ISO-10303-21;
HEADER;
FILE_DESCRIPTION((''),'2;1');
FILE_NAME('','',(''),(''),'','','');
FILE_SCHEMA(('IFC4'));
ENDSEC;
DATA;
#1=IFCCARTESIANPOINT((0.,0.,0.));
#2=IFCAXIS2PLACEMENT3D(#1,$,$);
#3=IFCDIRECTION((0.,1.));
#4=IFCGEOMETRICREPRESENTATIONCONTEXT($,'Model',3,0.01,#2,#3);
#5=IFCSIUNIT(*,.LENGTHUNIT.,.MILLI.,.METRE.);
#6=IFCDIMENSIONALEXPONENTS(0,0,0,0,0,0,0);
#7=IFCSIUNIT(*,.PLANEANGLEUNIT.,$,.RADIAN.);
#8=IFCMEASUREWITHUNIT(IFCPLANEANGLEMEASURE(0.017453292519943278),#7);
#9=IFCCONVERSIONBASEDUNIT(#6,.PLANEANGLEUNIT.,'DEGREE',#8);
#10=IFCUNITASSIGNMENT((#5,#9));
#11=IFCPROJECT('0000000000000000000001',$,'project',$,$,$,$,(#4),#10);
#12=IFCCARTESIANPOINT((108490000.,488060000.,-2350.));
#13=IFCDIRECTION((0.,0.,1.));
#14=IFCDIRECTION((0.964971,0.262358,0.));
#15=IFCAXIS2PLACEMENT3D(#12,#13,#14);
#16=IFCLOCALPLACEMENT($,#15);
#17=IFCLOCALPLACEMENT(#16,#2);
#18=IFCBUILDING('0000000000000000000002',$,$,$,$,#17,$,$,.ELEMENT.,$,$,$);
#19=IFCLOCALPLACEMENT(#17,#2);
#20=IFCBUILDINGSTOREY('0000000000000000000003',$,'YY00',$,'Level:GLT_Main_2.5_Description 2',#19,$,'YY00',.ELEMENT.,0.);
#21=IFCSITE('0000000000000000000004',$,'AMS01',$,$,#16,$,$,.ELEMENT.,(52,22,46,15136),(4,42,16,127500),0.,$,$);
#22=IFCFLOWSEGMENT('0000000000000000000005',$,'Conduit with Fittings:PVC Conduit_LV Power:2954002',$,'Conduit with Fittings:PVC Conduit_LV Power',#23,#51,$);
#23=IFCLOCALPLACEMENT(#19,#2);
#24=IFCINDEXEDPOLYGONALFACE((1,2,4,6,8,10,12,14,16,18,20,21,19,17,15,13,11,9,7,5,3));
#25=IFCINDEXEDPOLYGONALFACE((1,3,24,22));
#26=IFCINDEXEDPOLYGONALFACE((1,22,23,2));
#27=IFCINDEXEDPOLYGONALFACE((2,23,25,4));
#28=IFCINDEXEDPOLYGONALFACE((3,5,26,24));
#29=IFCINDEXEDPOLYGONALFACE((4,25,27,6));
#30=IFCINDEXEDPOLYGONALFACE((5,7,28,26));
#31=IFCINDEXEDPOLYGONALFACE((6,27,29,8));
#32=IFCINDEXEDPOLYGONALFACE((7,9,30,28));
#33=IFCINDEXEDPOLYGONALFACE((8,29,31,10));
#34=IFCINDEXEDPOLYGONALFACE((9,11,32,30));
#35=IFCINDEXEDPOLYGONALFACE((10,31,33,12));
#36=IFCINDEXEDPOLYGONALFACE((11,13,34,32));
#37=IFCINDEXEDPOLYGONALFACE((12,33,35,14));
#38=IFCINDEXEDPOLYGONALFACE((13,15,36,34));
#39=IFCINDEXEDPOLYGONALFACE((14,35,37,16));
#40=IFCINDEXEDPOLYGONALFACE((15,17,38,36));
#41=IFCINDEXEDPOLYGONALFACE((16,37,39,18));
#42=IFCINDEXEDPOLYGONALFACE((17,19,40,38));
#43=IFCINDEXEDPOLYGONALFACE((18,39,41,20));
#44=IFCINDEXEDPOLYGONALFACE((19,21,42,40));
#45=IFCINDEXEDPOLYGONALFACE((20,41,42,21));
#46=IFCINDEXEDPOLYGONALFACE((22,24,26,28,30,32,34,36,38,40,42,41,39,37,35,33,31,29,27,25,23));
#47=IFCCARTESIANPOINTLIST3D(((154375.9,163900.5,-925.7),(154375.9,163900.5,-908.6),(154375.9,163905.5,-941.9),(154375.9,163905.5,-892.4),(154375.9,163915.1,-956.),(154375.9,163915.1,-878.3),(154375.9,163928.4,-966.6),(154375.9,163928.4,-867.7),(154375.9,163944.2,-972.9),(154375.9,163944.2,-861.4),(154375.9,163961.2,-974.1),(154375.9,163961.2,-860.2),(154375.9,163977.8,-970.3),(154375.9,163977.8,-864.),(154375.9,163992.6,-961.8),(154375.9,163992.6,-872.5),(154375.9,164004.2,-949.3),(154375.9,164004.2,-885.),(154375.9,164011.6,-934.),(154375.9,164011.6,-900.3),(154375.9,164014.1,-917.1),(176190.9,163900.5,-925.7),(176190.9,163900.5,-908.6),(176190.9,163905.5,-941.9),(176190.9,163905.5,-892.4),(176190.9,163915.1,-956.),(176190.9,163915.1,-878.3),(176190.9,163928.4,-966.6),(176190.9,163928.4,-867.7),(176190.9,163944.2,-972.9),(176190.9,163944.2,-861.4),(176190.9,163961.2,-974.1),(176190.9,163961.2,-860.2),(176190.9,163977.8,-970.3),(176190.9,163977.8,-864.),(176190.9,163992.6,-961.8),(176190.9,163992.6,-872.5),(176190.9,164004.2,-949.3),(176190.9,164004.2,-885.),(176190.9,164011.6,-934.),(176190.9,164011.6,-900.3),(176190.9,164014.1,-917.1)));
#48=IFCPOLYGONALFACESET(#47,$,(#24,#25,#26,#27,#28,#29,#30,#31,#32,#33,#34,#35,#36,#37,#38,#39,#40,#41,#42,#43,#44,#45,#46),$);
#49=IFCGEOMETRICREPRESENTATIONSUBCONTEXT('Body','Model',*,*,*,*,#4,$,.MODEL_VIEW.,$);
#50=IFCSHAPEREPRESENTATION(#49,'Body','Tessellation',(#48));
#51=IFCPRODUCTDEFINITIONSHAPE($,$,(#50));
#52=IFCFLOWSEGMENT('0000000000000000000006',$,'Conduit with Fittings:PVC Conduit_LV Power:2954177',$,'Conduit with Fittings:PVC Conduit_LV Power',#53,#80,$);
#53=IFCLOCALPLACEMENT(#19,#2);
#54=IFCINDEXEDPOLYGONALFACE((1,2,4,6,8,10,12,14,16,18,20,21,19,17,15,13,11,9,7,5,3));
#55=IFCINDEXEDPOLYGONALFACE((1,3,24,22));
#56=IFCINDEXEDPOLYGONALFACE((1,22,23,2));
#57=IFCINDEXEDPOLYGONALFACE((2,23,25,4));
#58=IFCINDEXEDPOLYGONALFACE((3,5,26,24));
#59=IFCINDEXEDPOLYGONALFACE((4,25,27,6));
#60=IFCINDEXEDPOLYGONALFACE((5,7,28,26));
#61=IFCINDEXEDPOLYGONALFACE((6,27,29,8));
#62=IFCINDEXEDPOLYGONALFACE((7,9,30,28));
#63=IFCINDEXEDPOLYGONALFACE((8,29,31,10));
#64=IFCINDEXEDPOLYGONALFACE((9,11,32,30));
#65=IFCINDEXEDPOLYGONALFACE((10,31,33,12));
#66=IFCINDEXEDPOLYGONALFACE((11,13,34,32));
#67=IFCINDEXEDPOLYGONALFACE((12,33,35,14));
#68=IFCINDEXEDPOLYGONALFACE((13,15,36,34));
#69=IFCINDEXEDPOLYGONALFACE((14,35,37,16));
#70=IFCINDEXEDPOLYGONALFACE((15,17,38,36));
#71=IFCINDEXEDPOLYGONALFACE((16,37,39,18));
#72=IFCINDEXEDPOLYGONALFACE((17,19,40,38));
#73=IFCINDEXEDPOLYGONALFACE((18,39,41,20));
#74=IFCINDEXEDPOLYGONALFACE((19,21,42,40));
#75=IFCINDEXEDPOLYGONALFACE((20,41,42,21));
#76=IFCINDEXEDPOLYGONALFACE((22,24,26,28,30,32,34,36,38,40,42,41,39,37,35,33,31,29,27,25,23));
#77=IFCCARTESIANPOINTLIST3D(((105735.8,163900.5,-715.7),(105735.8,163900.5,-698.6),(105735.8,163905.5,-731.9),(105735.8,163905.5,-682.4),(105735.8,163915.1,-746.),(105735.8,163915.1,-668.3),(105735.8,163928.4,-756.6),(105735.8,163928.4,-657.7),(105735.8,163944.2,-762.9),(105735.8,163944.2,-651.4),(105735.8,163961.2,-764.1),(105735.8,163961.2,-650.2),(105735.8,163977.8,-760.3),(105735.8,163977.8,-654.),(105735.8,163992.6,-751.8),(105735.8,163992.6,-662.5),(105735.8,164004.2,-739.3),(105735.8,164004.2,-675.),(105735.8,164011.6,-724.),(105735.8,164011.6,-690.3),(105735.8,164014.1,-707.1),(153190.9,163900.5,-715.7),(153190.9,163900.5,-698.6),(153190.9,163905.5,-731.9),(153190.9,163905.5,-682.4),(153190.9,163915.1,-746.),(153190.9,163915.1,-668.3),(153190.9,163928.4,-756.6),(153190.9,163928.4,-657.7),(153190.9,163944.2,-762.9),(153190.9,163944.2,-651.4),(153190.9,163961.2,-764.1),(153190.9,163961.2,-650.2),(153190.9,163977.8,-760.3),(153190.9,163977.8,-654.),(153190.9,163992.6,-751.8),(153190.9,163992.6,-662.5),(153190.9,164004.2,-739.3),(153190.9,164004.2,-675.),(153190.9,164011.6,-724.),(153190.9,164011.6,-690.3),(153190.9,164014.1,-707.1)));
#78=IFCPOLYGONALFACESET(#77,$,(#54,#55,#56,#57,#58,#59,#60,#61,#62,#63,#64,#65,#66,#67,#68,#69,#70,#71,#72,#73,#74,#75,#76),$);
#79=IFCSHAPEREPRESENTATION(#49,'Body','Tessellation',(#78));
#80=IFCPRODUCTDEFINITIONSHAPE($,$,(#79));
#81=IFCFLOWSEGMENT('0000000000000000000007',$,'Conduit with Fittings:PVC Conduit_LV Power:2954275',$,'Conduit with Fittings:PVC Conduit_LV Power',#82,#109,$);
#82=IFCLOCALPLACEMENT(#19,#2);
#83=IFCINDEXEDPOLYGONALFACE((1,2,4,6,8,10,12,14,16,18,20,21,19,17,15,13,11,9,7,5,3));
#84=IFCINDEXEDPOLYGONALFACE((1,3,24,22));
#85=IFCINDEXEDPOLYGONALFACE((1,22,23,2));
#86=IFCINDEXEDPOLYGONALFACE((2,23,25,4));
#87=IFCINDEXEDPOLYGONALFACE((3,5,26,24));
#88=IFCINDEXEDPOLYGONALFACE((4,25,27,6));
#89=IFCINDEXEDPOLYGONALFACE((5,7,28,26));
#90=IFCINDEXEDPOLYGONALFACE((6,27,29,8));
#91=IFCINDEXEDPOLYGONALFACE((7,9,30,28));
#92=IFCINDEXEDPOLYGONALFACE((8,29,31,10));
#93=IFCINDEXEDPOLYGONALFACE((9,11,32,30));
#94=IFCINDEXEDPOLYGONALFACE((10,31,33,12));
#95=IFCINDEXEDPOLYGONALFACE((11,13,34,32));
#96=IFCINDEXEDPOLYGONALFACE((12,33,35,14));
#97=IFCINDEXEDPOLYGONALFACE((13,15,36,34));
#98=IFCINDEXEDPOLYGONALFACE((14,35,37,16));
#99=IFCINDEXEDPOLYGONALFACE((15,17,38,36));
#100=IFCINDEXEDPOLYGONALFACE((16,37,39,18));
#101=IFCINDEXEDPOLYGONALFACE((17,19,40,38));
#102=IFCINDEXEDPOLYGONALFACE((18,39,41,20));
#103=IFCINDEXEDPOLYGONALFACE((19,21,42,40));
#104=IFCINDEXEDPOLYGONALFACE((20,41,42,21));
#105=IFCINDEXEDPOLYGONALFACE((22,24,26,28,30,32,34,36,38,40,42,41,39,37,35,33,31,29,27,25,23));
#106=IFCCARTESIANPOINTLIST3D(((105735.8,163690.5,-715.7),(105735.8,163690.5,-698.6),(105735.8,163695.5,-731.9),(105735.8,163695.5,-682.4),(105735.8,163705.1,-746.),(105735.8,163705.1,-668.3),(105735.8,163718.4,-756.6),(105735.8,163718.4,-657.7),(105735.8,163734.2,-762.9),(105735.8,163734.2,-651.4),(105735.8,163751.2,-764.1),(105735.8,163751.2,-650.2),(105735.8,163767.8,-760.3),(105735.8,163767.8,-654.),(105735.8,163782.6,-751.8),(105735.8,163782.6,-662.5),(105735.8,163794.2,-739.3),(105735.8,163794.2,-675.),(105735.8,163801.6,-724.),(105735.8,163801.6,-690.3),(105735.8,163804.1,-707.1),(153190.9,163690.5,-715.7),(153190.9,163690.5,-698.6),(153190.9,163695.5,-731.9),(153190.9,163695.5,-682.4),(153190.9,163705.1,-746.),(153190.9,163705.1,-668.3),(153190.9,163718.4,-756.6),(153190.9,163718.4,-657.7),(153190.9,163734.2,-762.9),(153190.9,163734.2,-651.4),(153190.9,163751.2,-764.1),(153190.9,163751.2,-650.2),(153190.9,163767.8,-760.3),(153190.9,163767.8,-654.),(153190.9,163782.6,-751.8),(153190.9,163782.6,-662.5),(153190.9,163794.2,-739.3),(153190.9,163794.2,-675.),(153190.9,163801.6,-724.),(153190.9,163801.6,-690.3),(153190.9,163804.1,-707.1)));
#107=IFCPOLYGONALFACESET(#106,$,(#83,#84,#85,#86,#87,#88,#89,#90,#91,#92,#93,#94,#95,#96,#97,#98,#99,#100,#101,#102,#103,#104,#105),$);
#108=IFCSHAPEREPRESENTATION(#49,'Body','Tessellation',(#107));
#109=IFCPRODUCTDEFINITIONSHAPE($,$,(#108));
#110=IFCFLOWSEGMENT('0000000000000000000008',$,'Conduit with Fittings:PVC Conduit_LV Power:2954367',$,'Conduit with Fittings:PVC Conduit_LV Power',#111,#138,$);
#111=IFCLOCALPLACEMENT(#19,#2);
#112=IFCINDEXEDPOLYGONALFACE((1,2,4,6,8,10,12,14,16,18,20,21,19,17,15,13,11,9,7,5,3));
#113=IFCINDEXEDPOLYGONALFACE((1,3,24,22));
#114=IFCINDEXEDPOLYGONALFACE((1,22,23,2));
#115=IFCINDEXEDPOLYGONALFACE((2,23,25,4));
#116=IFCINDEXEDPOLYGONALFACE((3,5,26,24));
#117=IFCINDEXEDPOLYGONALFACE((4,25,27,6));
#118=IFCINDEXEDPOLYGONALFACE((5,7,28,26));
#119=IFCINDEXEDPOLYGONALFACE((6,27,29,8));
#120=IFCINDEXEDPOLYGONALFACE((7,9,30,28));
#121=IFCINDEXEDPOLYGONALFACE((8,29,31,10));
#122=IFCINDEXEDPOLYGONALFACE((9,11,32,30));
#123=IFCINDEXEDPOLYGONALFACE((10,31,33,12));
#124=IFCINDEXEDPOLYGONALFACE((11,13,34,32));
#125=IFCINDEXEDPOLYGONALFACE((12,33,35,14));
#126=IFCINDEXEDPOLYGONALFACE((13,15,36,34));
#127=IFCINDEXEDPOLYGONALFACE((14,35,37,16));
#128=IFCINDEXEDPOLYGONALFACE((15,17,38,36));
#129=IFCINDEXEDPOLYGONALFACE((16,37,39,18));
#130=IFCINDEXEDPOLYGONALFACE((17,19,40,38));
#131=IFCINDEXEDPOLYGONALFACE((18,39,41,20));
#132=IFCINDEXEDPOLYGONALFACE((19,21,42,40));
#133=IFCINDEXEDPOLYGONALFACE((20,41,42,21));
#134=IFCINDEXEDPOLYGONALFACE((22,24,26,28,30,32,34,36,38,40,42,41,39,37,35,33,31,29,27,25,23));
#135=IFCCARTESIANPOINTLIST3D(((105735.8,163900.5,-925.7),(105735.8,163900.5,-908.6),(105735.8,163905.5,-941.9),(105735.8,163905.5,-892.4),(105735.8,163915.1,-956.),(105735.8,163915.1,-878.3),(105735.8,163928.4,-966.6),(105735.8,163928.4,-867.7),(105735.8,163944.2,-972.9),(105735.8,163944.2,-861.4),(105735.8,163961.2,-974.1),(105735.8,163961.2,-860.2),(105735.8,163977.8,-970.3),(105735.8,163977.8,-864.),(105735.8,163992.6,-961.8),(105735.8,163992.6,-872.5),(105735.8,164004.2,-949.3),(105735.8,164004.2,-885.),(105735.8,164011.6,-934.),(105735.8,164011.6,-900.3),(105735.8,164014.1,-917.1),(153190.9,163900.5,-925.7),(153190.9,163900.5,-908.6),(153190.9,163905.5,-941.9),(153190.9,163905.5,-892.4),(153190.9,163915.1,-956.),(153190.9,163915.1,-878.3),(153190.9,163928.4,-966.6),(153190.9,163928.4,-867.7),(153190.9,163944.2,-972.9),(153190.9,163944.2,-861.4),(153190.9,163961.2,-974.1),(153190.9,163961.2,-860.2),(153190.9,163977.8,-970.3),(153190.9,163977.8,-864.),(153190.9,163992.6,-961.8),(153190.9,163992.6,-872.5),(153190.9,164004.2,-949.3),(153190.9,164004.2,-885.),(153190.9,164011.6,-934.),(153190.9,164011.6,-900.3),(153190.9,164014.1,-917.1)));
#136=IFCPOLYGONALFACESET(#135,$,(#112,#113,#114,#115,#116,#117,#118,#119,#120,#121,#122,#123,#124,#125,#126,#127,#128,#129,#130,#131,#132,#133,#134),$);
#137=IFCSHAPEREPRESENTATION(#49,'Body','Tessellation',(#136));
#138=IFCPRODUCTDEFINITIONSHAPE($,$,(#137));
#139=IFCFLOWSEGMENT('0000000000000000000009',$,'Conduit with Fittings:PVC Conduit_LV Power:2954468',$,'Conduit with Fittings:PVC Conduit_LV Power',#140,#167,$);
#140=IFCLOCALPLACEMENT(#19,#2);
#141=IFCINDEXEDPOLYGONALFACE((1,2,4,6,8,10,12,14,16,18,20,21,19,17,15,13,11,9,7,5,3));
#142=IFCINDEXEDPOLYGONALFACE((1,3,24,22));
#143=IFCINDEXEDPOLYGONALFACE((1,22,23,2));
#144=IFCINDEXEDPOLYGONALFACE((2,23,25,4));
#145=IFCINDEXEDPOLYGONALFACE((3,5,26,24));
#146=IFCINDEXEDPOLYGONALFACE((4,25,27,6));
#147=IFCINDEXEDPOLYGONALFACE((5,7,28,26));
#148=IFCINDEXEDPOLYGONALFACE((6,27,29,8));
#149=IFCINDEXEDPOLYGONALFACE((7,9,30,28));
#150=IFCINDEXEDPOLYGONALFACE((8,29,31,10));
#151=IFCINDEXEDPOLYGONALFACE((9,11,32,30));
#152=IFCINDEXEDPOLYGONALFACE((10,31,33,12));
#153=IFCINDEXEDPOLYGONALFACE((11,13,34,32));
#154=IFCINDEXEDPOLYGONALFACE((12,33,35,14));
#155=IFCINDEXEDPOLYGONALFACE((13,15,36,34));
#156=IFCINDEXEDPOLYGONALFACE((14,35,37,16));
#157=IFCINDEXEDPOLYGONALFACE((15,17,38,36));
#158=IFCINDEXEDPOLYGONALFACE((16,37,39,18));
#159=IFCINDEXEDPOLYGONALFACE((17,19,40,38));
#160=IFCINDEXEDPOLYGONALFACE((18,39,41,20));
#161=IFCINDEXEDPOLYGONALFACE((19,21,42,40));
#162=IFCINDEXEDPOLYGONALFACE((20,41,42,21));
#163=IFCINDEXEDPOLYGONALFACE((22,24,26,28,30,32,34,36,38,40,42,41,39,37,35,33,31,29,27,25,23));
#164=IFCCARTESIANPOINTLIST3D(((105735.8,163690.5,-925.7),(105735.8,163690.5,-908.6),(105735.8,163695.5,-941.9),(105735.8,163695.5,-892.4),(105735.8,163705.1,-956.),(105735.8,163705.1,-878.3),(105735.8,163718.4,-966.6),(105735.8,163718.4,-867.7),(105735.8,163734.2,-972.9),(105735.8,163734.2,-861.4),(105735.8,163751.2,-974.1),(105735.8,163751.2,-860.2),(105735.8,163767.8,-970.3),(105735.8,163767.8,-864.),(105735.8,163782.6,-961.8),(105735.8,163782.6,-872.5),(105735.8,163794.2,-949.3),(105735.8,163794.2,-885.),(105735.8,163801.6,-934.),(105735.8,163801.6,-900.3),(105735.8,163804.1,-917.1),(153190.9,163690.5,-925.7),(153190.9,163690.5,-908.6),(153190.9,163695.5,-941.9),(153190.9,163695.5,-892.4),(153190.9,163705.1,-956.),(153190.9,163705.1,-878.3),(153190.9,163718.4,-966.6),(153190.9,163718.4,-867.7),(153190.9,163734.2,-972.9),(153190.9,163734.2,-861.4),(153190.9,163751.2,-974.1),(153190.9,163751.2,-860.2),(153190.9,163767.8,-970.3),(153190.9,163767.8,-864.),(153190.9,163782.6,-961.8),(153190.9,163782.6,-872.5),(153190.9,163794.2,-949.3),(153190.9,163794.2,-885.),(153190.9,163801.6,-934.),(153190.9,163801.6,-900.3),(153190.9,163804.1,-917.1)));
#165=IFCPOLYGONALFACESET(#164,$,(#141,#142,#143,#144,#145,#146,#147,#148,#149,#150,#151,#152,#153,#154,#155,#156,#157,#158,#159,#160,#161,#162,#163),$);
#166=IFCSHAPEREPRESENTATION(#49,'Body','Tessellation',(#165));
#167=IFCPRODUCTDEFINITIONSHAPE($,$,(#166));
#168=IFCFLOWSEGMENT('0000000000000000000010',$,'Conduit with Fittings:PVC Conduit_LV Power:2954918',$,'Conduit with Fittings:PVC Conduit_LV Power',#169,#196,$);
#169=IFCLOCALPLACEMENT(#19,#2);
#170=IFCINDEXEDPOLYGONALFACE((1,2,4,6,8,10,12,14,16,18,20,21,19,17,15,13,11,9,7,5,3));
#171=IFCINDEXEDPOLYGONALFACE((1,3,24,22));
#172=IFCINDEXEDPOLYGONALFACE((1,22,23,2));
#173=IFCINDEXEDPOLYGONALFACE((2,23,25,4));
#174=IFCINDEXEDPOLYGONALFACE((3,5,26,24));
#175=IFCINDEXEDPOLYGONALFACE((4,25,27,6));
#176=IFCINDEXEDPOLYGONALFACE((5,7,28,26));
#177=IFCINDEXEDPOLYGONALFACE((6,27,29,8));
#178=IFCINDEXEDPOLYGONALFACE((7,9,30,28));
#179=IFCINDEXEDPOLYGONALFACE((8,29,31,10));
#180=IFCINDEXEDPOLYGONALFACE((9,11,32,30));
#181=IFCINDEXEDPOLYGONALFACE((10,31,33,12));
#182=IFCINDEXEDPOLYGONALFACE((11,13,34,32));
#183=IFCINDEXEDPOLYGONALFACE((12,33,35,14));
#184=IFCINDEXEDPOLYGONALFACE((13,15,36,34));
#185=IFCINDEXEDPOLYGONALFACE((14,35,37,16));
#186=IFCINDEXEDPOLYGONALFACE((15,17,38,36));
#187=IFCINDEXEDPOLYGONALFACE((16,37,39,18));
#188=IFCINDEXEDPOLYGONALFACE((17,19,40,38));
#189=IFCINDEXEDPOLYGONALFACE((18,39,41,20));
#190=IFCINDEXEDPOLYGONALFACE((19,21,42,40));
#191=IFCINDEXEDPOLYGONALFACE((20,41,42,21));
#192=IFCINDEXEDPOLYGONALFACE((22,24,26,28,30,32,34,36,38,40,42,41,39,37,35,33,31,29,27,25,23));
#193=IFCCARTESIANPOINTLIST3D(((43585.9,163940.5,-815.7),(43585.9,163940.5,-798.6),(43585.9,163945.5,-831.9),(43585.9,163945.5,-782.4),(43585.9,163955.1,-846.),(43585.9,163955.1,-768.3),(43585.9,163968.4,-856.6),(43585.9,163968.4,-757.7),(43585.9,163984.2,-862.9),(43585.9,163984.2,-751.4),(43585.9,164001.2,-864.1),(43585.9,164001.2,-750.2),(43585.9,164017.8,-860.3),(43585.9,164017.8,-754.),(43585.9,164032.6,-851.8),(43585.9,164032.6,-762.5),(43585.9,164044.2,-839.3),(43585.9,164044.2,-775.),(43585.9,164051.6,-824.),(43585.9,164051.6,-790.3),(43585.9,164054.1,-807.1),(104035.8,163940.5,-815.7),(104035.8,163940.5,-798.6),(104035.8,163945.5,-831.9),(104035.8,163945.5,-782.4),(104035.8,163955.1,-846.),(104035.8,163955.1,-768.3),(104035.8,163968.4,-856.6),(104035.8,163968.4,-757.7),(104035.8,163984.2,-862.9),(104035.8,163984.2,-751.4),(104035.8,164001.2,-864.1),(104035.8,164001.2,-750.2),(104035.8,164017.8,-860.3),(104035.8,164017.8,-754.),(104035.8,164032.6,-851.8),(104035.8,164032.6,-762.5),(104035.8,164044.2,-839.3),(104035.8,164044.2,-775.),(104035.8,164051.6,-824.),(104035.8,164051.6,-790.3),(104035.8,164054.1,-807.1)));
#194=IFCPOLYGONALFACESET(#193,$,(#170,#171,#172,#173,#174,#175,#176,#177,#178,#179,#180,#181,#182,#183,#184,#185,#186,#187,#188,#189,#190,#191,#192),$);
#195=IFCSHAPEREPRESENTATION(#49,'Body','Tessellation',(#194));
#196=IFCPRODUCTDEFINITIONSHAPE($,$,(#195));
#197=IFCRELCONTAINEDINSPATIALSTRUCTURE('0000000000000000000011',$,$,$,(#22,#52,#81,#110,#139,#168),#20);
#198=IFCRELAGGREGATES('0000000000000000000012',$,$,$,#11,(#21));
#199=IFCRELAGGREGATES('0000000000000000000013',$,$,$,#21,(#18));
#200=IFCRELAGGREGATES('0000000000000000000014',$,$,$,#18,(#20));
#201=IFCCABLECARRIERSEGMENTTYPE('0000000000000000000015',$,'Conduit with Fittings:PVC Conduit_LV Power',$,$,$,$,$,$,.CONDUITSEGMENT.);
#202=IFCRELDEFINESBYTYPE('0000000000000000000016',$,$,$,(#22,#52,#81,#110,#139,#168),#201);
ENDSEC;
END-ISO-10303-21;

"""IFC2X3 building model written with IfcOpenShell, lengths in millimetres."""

from ifc_helpers import new_model, entity, si_unit, converted_unit, direction, frame, frame_2d, origin, place, context, subcontext, project, spatial, circle, extrude, type_object, element, save


model = new_model("IFC2X3")

# Units and contexts
model_context = context("Model", 3, precision=0.01, world=origin(), true_north=direction((0.0, 1.0)))
body_context = subcontext(model_context, "Body", "Model", "MODEL_VIEW")
ifc_project = project(units=[si_unit("LENGTHUNIT", "METRE", prefix="MILLI"), converted_unit("PLANEANGLEUNIT", "DEGREE", entity("IfcPlaneAngleMeasure", 0.017453292519943278), si_unit("PLANEANGLEUNIT", "RADIAN"), dimensions=[0, 0, 0, 0, 0, 0, 0])], contexts=[model_context])

# Site, building, storey
site_placement = place(None, frame((108490000.0, 488060000.0, -2350.0), z_axis=(0.0, 0.0, 1.0), x_axis=(0.964971, 0.262358, 0.0)))
site = spatial("IfcSite", under=ifc_project, at=site_placement, Name="AMS01", CompositionType="ELEMENT", RefLatitude=(52, 22, 46, 15136), RefLongitude=(4, 42, 16, 127500), RefElevation=0.0)
building_placement = place(site_placement, origin())
building = spatial("IfcBuilding", under=site, at=building_placement, CompositionType="ELEMENT")
storey_placement = place(building_placement, origin())
storey = spatial("IfcBuildingStorey", under=building, at=storey_placement, Name="YY00", ObjectType="Level:GLT_Main_2.5_Description 2", LongName="YY00", CompositionType="ELEMENT", Elevation=0.0)

# Flow segments
cable_carrier_segment_type = type_object("IfcCableCarrierSegmentType", Name="Conduit with Fittings:PVC Conduit_LV Power", PredefinedType="CONDUITSEGMENT")
flow_segment_1_placement = place(storey_placement, origin())
element("IfcFlowSegment", 1, at=flow_segment_1_placement, inside=storey, type_object=cable_carrier_segment_type, Name="Conduit with Fittings:PVC Conduit_LV Power:2954002", ObjectType="Conduit with Fittings:PVC Conduit_LV Power", context=body_context, shape_type="SweptSolid", body=[
    extrude(circle(Radius=57.2, at=frame_2d((0.0, 0.0), x_axis=(1.0, 0.0))), frame((154375.9, 163957.0, -917.1), z_axis=(1.0, 0.0, 0.0), x_axis=(0.0, 1.0, 0.0)), (0.0, 0.0, 1.0), 21815.0),
])
flow_segment_2_placement = place(storey_placement, origin())
element("IfcFlowSegment", 2, at=flow_segment_2_placement, inside=storey, type_object=cable_carrier_segment_type, Name="Conduit with Fittings:PVC Conduit_LV Power:2954177", ObjectType="Conduit with Fittings:PVC Conduit_LV Power", context=body_context, shape_type="SweptSolid", body=[
    extrude(circle(Radius=57.2, at=frame_2d((0.0, 0.0), x_axis=(1.0, 0.0))), frame((105735.8, 163957.0, -707.1), z_axis=(1.0, 0.0, 0.0), x_axis=(0.0, 1.0, 0.0)), (0.0, 0.0, 1.0), 47455.1),
])
flow_segment_3_placement = place(storey_placement, origin())
element("IfcFlowSegment", 3, at=flow_segment_3_placement, inside=storey, type_object=cable_carrier_segment_type, Name="Conduit with Fittings:PVC Conduit_LV Power:2954275", ObjectType="Conduit with Fittings:PVC Conduit_LV Power", context=body_context, shape_type="SweptSolid", body=[
    extrude(circle(Radius=57.2, at=frame_2d((0.0, 0.0), x_axis=(1.0, 0.0))), frame((105735.8, 163747.0, -707.1), z_axis=(1.0, 0.0, 0.0), x_axis=(0.0, 1.0, 0.0)), (0.0, 0.0, 1.0), 47455.1),
])
flow_segment_4_placement = place(storey_placement, origin())
element("IfcFlowSegment", 4, at=flow_segment_4_placement, inside=storey, type_object=cable_carrier_segment_type, Name="Conduit with Fittings:PVC Conduit_LV Power:2954367", ObjectType="Conduit with Fittings:PVC Conduit_LV Power", context=body_context, shape_type="SweptSolid", body=[
    extrude(circle(Radius=57.2, at=frame_2d((0.0, 0.0), x_axis=(1.0, 0.0))), frame((105735.8, 163957.0, -917.1), z_axis=(1.0, 0.0, 0.0), x_axis=(0.0, 1.0, 0.0)), (0.0, 0.0, 1.0), 47455.1),
])
flow_segment_5_placement = place(storey_placement, origin())
element("IfcFlowSegment", 5, at=flow_segment_5_placement, inside=storey, type_object=cable_carrier_segment_type, Name="Conduit with Fittings:PVC Conduit_LV Power:2954468", ObjectType="Conduit with Fittings:PVC Conduit_LV Power", context=body_context, shape_type="SweptSolid", body=[
    extrude(circle(Radius=57.2, at=frame_2d((0.0, 0.0), x_axis=(1.0, 0.0))), frame((105735.8, 163747.0, -917.1), z_axis=(1.0, 0.0, 0.0), x_axis=(0.0, 1.0, 0.0)), (0.0, 0.0, 1.0), 47455.1),
])
flow_segment_6_placement = place(storey_placement, origin())
element("IfcFlowSegment", 6, at=flow_segment_6_placement, inside=storey, type_object=cable_carrier_segment_type, Name="Conduit with Fittings:PVC Conduit_LV Power:2954918", ObjectType="Conduit with Fittings:PVC Conduit_LV Power", context=body_context, shape_type="SweptSolid", body=[
    extrude(circle(Radius=57.2, at=frame_2d((0.0, 0.0), x_axis=(1.0, 0.0))), frame((43585.9, 163997.0, -807.1), z_axis=(1.0, 0.0, 0.0), x_axis=(0.0, 1.0, 0.0)), (0.0, 0.0, 1.0), 60450.0),
])

save(model, "model.ifc")
